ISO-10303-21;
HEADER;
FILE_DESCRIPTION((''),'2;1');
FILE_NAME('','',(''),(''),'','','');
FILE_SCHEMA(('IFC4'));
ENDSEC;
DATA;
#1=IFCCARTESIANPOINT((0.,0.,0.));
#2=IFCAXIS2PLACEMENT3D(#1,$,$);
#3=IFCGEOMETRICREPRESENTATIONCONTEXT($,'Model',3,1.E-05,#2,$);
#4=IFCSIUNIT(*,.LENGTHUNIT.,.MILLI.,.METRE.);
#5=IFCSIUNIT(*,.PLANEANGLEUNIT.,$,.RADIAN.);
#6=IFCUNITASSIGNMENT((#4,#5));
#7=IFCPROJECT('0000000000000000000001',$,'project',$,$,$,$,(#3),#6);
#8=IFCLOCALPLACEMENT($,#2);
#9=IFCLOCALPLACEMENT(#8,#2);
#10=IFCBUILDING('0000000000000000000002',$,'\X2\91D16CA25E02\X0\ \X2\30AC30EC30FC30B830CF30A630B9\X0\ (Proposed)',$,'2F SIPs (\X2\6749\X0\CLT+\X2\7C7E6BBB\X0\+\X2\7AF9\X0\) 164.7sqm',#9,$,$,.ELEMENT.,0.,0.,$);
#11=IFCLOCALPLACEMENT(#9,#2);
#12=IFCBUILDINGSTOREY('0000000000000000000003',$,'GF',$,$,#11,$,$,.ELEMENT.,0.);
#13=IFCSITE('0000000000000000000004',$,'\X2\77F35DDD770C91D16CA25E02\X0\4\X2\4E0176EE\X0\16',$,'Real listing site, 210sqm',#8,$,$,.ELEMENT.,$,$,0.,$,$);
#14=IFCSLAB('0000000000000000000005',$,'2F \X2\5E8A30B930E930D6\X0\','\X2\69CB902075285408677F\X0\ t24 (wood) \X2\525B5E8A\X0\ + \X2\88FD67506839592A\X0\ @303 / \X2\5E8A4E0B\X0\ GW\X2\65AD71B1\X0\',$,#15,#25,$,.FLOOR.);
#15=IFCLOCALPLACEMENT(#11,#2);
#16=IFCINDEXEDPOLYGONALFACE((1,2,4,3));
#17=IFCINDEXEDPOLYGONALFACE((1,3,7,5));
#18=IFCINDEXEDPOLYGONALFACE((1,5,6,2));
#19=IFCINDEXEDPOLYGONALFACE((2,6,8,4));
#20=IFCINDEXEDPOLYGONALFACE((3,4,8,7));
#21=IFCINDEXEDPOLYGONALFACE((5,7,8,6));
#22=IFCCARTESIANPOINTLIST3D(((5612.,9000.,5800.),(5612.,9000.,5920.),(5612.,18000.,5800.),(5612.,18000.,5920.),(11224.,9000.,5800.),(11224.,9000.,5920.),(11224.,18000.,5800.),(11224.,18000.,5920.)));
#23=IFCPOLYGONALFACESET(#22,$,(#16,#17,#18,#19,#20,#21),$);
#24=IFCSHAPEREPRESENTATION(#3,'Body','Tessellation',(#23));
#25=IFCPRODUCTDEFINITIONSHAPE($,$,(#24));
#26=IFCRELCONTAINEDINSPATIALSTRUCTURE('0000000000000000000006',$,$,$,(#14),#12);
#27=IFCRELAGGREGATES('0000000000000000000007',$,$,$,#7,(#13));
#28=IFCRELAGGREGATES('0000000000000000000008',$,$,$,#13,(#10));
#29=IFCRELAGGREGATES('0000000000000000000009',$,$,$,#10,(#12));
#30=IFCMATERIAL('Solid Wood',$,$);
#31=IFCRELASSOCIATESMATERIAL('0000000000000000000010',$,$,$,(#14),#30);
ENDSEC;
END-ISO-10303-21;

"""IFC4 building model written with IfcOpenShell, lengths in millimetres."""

from ifc_helpers import new_model, si_unit, frame, frame_2d, origin, place, context, project, spatial, rectangle, extrude, material, element, save


model = new_model("IFC4")

# Units and contexts
model_context = context("Model", 3, precision=1e-05, world=origin())
ifc_project = project(units=[si_unit("LENGTHUNIT", "METRE", prefix="MILLI"), si_unit("PLANEANGLEUNIT", "RADIAN")], contexts=[model_context])

# Site, building, storey
site_placement = place(None, origin())
site = spatial("IfcSite", under=ifc_project, at=site_placement, Name="石川県金沢市4丁目16", ObjectType="Real listing site, 210sqm", CompositionType="ELEMENT", RefElevation=0.0)
building_placement = place(site_placement, origin())
building = spatial("IfcBuilding", under=site, at=building_placement, Name="金沢市 ガレージハウス (Proposed)", ObjectType="2F SIPs (杉CLT+籾殻+竹) 164.7sqm", CompositionType="ELEMENT", ElevationOfRefHeight=0.0, ElevationOfTerrain=0.0)
storey_placement = place(building_placement, origin())
storey = spatial("IfcBuildingStorey", under=building, at=storey_placement, Name="GF", CompositionType="ELEMENT", Elevation=0.0)

# Slab
ifc_material_1 = material(Name="Solid Wood")
slab_placement = place(storey_placement, frame((2806.0, 4500.0, 2900.0)))
element("IfcSlab", 1, at=slab_placement, inside=storey, material=ifc_material_1, Name="2F 床スラブ", Description="構造用合板 t24 (wood) 剛床 + 製材根太 @303 / 床下 GW断熱", PredefinedType="FLOOR", context=model_context, shape_type="SweptSolid", body=[
    extrude(rectangle(XDim=5612.0, YDim=9000.0, at=frame_2d((2806.0, 4500.0))), frame((2806.0, 4500.0, 2900.0)), (0.0, 0.0, 1.0), 120.0),
])

save(model, "model.ifc")
